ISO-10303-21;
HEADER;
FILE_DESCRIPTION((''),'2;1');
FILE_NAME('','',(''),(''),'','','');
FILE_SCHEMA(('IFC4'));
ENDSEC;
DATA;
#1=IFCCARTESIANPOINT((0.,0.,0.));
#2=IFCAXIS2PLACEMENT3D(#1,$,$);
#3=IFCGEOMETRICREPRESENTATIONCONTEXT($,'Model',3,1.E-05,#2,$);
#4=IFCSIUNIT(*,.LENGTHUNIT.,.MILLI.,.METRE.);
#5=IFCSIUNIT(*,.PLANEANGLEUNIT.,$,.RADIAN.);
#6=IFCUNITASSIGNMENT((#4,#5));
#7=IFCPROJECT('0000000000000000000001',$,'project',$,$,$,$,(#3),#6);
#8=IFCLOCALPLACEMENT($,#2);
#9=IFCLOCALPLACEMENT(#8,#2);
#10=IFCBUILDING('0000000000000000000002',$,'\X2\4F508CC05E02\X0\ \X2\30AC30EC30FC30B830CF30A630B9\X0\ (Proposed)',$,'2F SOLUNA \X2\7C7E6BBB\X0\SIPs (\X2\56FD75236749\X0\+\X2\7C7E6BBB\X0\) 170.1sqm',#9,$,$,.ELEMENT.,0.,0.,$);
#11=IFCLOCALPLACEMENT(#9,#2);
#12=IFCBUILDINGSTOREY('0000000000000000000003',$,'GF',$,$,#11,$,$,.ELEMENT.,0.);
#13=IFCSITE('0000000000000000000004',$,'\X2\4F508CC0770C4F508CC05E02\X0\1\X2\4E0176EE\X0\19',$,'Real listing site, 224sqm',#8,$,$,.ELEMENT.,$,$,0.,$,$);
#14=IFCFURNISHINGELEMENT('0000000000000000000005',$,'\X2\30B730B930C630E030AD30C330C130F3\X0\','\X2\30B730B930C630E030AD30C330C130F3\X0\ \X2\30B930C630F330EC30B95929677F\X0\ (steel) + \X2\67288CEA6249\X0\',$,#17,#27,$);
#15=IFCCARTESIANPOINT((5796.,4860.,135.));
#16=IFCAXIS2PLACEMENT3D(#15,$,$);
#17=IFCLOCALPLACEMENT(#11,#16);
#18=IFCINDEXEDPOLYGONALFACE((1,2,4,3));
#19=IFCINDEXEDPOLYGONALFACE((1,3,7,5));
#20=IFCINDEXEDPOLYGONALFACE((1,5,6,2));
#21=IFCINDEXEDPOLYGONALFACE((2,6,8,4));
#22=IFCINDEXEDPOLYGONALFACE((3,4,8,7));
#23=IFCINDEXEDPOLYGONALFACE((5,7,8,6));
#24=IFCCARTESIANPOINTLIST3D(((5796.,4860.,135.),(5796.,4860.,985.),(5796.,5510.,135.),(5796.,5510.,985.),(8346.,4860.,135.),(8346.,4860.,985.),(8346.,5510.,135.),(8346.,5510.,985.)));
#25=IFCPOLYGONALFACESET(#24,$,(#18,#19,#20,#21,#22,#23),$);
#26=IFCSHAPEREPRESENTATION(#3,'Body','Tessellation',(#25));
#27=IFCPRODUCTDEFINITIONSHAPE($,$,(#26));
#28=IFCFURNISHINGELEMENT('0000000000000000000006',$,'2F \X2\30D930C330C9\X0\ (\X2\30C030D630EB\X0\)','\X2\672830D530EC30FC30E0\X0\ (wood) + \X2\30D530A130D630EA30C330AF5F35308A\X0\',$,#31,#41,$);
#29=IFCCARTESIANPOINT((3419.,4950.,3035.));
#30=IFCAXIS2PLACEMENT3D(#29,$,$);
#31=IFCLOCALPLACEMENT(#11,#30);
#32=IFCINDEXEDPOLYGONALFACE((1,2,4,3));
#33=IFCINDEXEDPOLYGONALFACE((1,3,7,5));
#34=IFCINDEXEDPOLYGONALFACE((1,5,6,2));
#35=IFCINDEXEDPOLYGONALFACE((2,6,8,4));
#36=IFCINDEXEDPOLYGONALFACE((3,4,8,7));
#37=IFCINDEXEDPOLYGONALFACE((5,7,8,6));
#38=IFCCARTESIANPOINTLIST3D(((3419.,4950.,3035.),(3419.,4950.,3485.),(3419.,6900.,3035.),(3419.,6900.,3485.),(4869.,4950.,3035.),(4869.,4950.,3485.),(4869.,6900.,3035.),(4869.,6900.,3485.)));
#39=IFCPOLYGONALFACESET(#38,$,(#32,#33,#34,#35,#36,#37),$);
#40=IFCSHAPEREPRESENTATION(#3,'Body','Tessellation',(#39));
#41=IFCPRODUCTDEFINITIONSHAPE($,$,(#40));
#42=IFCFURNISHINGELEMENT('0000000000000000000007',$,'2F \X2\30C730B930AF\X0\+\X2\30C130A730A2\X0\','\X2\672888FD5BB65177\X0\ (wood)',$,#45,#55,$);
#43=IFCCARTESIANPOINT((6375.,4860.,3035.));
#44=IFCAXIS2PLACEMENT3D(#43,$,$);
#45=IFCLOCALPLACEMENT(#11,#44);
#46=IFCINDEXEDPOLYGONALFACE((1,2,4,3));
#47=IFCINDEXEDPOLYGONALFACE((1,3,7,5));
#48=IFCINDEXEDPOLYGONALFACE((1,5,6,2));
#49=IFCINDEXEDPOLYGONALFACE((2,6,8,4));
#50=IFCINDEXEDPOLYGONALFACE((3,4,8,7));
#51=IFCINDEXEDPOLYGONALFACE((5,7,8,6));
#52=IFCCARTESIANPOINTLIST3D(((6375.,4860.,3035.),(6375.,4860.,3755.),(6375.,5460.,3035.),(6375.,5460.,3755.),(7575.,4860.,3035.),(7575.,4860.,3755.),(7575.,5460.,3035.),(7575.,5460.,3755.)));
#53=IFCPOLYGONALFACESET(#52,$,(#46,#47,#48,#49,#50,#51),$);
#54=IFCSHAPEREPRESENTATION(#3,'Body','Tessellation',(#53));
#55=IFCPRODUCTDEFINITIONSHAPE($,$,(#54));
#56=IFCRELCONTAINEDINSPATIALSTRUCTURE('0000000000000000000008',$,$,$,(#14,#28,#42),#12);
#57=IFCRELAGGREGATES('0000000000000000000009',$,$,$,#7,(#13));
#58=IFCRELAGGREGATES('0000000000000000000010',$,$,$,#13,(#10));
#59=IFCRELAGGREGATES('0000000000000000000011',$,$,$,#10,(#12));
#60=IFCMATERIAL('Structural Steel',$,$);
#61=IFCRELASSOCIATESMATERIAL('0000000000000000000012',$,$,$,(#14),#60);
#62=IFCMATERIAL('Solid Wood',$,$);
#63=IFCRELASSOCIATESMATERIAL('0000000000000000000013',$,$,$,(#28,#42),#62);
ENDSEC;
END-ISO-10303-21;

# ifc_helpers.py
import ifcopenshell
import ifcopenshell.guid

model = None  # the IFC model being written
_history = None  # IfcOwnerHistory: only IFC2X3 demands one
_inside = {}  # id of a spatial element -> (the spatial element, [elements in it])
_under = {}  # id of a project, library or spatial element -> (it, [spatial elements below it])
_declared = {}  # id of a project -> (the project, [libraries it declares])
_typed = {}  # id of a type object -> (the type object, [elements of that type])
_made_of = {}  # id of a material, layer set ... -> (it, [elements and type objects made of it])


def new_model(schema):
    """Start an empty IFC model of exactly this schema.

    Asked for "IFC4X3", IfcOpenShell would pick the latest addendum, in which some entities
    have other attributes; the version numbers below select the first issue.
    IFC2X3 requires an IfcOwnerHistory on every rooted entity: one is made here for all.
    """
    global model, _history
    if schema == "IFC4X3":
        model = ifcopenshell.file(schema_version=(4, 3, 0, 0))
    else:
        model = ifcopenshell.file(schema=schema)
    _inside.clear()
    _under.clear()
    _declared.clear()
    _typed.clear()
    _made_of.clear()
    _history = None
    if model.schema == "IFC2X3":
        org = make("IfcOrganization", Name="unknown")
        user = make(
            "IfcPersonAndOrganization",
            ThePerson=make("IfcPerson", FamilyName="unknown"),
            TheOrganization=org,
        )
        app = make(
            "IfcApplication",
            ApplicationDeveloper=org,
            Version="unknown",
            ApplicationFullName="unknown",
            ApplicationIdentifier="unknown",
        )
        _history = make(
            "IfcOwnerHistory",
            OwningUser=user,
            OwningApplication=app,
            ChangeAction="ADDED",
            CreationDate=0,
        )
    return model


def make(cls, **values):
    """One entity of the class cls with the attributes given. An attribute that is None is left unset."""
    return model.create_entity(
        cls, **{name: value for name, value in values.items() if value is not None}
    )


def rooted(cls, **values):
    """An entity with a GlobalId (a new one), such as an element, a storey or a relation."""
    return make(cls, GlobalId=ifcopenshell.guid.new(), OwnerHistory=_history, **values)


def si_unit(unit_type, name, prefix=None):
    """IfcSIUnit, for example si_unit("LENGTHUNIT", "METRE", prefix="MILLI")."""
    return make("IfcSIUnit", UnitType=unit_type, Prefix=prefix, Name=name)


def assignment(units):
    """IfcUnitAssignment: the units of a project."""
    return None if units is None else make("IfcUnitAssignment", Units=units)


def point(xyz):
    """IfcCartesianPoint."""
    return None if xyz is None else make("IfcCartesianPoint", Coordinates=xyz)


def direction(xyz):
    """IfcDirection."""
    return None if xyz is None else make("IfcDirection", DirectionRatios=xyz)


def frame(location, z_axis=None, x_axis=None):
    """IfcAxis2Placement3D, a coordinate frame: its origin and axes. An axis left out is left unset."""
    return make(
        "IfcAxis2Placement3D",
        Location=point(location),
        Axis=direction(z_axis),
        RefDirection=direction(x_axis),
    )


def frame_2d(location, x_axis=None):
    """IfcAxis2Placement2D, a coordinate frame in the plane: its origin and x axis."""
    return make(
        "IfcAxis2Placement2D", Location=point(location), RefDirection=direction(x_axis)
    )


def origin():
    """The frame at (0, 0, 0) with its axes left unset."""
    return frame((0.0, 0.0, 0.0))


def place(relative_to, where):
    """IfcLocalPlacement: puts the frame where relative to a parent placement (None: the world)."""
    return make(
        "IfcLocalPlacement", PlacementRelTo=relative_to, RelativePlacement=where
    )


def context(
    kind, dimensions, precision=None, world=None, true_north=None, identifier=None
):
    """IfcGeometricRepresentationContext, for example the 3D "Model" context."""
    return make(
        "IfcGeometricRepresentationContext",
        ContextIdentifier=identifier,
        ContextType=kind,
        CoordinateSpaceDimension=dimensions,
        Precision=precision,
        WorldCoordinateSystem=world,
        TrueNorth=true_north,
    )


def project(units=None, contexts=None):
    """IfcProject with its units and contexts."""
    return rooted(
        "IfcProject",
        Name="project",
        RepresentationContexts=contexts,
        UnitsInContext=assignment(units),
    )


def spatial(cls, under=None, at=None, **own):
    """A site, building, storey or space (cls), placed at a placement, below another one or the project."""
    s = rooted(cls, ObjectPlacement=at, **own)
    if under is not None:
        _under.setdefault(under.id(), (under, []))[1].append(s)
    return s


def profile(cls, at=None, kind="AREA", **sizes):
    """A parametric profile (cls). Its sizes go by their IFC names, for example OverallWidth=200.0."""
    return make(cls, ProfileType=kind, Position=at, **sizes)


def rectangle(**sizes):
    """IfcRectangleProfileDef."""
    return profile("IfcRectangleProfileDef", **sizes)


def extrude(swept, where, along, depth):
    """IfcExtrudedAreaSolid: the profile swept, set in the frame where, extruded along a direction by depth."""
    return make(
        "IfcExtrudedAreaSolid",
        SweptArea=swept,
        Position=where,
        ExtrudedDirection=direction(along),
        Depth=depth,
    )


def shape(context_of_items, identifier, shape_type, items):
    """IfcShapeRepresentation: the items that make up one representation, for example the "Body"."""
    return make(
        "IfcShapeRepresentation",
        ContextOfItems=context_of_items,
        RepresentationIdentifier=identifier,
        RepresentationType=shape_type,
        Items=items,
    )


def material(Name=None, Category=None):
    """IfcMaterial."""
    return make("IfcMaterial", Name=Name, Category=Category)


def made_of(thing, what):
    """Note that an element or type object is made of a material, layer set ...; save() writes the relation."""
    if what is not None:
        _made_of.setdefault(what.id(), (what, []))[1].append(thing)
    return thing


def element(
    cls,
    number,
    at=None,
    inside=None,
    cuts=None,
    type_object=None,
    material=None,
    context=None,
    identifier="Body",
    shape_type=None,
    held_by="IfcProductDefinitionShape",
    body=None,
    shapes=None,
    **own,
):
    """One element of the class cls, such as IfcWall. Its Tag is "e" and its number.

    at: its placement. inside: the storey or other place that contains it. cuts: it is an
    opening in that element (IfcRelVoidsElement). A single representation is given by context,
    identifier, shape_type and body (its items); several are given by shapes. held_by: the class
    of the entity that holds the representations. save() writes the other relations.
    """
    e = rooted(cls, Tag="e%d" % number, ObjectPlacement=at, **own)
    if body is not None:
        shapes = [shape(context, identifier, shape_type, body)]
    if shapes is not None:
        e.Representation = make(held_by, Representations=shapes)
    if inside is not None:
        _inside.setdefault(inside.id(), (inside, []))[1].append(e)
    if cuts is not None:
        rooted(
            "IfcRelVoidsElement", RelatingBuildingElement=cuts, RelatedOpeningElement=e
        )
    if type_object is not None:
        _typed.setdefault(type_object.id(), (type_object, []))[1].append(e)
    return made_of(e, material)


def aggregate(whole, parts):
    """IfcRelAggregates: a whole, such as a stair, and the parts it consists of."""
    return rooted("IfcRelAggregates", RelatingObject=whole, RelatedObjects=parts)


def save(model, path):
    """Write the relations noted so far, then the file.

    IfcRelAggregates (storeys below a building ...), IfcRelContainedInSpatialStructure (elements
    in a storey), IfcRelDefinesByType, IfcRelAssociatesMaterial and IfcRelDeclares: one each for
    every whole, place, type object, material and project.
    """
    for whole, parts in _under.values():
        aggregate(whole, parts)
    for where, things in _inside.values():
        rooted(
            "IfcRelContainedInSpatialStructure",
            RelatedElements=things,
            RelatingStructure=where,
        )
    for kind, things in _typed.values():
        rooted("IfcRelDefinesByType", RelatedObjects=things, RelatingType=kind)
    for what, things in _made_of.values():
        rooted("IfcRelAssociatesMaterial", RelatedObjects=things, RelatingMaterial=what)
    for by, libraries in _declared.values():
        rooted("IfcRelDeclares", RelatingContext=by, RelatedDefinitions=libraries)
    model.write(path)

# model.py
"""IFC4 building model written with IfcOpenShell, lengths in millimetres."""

from ifc_helpers import new_model, si_unit, frame, frame_2d, origin, place, context, project, spatial, rectangle, extrude, material, element, save


model = new_model("IFC4")

# Units and contexts
model_context = context("Model", 3, precision=1e-05, world=origin())
ifc_project = project(units=[si_unit("LENGTHUNIT", "METRE", prefix="MILLI"), si_unit("PLANEANGLEUNIT", "RADIAN")], contexts=[model_context])

# Site, building, storey
site_placement = place(None, origin())
site = spatial("IfcSite", under=ifc_project, at=site_placement, Name="佐賀県佐賀市1丁目19", ObjectType="Real listing site, 224sqm", CompositionType="ELEMENT", RefElevation=0.0)
building_placement = place(site_placement, origin())
building = spatial("IfcBuilding", under=site, at=building_placement, Name="佐賀市 ガレージハウス (Proposed)", ObjectType="2F SOLUNA 籾殻SIPs (国産杉+籾殻) 170.1sqm", CompositionType="ELEMENT", ElevationOfRefHeight=0.0, ElevationOfTerrain=0.0)
storey_placement = place(building_placement, origin())
storey = spatial("IfcBuildingStorey", under=building, at=storey_placement, Name="GF", CompositionType="ELEMENT", Elevation=0.0)

# Shared definitions
ifc_material_1 = material(Name="Solid Wood")

# Shared definitions
ifc_material_2 = material(Name="Structural Steel")

# Furnishing elements
furnishing_1_placement = place(storey_placement, frame((5796.0, 4860.0, 135.0)))
element("IfcFurnishingElement", 1, at=furnishing_1_placement, inside=storey, material=ifc_material_2, Name="システムキッチン", Description="システムキッチン ステンレス天板 (steel) + 木質扉", context=model_context, shape_type="SweptSolid", body=[
    extrude(rectangle(XDim=2550.0, YDim=650.0, at=frame_2d((1275.0, 325.0))), frame((5796.0, 4860.0, 135.0)), (0.0, 0.0, 1.0), 850.0),
])
furnishing_2_placement = place(storey_placement, frame((3419.0, 4950.0, 3035.0)))
element("IfcFurnishingElement", 2, at=furnishing_2_placement, inside=storey, material=ifc_material_1, Name="2F ベッド (ダブル)", Description="木フレーム (wood) + ファブリック張り", context=model_context, shape_type="SweptSolid", body=[
    extrude(rectangle(XDim=1450.0, YDim=1950.0, at=frame_2d((725.0, 975.0))), frame((3419.0, 4950.0, 3035.0)), (0.0, 0.0, 1.0), 450.0),
])
furnishing_3_placement = place(storey_placement, frame((6375.0, 4860.0, 3035.0)))
element("IfcFurnishingElement", 3, at=furnishing_3_placement, inside=storey, material=ifc_material_1, Name="2F デスク+チェア", Description="木製家具 (wood)", context=model_context, shape_type="SweptSolid", body=[
    extrude(rectangle(XDim=1200.0, YDim=600.0, at=frame_2d((600.0, 300.0))), frame((6375.0, 4860.0, 3035.0)), (0.0, 0.0, 1.0), 720.0),
])

save(model, "model.ifc")
